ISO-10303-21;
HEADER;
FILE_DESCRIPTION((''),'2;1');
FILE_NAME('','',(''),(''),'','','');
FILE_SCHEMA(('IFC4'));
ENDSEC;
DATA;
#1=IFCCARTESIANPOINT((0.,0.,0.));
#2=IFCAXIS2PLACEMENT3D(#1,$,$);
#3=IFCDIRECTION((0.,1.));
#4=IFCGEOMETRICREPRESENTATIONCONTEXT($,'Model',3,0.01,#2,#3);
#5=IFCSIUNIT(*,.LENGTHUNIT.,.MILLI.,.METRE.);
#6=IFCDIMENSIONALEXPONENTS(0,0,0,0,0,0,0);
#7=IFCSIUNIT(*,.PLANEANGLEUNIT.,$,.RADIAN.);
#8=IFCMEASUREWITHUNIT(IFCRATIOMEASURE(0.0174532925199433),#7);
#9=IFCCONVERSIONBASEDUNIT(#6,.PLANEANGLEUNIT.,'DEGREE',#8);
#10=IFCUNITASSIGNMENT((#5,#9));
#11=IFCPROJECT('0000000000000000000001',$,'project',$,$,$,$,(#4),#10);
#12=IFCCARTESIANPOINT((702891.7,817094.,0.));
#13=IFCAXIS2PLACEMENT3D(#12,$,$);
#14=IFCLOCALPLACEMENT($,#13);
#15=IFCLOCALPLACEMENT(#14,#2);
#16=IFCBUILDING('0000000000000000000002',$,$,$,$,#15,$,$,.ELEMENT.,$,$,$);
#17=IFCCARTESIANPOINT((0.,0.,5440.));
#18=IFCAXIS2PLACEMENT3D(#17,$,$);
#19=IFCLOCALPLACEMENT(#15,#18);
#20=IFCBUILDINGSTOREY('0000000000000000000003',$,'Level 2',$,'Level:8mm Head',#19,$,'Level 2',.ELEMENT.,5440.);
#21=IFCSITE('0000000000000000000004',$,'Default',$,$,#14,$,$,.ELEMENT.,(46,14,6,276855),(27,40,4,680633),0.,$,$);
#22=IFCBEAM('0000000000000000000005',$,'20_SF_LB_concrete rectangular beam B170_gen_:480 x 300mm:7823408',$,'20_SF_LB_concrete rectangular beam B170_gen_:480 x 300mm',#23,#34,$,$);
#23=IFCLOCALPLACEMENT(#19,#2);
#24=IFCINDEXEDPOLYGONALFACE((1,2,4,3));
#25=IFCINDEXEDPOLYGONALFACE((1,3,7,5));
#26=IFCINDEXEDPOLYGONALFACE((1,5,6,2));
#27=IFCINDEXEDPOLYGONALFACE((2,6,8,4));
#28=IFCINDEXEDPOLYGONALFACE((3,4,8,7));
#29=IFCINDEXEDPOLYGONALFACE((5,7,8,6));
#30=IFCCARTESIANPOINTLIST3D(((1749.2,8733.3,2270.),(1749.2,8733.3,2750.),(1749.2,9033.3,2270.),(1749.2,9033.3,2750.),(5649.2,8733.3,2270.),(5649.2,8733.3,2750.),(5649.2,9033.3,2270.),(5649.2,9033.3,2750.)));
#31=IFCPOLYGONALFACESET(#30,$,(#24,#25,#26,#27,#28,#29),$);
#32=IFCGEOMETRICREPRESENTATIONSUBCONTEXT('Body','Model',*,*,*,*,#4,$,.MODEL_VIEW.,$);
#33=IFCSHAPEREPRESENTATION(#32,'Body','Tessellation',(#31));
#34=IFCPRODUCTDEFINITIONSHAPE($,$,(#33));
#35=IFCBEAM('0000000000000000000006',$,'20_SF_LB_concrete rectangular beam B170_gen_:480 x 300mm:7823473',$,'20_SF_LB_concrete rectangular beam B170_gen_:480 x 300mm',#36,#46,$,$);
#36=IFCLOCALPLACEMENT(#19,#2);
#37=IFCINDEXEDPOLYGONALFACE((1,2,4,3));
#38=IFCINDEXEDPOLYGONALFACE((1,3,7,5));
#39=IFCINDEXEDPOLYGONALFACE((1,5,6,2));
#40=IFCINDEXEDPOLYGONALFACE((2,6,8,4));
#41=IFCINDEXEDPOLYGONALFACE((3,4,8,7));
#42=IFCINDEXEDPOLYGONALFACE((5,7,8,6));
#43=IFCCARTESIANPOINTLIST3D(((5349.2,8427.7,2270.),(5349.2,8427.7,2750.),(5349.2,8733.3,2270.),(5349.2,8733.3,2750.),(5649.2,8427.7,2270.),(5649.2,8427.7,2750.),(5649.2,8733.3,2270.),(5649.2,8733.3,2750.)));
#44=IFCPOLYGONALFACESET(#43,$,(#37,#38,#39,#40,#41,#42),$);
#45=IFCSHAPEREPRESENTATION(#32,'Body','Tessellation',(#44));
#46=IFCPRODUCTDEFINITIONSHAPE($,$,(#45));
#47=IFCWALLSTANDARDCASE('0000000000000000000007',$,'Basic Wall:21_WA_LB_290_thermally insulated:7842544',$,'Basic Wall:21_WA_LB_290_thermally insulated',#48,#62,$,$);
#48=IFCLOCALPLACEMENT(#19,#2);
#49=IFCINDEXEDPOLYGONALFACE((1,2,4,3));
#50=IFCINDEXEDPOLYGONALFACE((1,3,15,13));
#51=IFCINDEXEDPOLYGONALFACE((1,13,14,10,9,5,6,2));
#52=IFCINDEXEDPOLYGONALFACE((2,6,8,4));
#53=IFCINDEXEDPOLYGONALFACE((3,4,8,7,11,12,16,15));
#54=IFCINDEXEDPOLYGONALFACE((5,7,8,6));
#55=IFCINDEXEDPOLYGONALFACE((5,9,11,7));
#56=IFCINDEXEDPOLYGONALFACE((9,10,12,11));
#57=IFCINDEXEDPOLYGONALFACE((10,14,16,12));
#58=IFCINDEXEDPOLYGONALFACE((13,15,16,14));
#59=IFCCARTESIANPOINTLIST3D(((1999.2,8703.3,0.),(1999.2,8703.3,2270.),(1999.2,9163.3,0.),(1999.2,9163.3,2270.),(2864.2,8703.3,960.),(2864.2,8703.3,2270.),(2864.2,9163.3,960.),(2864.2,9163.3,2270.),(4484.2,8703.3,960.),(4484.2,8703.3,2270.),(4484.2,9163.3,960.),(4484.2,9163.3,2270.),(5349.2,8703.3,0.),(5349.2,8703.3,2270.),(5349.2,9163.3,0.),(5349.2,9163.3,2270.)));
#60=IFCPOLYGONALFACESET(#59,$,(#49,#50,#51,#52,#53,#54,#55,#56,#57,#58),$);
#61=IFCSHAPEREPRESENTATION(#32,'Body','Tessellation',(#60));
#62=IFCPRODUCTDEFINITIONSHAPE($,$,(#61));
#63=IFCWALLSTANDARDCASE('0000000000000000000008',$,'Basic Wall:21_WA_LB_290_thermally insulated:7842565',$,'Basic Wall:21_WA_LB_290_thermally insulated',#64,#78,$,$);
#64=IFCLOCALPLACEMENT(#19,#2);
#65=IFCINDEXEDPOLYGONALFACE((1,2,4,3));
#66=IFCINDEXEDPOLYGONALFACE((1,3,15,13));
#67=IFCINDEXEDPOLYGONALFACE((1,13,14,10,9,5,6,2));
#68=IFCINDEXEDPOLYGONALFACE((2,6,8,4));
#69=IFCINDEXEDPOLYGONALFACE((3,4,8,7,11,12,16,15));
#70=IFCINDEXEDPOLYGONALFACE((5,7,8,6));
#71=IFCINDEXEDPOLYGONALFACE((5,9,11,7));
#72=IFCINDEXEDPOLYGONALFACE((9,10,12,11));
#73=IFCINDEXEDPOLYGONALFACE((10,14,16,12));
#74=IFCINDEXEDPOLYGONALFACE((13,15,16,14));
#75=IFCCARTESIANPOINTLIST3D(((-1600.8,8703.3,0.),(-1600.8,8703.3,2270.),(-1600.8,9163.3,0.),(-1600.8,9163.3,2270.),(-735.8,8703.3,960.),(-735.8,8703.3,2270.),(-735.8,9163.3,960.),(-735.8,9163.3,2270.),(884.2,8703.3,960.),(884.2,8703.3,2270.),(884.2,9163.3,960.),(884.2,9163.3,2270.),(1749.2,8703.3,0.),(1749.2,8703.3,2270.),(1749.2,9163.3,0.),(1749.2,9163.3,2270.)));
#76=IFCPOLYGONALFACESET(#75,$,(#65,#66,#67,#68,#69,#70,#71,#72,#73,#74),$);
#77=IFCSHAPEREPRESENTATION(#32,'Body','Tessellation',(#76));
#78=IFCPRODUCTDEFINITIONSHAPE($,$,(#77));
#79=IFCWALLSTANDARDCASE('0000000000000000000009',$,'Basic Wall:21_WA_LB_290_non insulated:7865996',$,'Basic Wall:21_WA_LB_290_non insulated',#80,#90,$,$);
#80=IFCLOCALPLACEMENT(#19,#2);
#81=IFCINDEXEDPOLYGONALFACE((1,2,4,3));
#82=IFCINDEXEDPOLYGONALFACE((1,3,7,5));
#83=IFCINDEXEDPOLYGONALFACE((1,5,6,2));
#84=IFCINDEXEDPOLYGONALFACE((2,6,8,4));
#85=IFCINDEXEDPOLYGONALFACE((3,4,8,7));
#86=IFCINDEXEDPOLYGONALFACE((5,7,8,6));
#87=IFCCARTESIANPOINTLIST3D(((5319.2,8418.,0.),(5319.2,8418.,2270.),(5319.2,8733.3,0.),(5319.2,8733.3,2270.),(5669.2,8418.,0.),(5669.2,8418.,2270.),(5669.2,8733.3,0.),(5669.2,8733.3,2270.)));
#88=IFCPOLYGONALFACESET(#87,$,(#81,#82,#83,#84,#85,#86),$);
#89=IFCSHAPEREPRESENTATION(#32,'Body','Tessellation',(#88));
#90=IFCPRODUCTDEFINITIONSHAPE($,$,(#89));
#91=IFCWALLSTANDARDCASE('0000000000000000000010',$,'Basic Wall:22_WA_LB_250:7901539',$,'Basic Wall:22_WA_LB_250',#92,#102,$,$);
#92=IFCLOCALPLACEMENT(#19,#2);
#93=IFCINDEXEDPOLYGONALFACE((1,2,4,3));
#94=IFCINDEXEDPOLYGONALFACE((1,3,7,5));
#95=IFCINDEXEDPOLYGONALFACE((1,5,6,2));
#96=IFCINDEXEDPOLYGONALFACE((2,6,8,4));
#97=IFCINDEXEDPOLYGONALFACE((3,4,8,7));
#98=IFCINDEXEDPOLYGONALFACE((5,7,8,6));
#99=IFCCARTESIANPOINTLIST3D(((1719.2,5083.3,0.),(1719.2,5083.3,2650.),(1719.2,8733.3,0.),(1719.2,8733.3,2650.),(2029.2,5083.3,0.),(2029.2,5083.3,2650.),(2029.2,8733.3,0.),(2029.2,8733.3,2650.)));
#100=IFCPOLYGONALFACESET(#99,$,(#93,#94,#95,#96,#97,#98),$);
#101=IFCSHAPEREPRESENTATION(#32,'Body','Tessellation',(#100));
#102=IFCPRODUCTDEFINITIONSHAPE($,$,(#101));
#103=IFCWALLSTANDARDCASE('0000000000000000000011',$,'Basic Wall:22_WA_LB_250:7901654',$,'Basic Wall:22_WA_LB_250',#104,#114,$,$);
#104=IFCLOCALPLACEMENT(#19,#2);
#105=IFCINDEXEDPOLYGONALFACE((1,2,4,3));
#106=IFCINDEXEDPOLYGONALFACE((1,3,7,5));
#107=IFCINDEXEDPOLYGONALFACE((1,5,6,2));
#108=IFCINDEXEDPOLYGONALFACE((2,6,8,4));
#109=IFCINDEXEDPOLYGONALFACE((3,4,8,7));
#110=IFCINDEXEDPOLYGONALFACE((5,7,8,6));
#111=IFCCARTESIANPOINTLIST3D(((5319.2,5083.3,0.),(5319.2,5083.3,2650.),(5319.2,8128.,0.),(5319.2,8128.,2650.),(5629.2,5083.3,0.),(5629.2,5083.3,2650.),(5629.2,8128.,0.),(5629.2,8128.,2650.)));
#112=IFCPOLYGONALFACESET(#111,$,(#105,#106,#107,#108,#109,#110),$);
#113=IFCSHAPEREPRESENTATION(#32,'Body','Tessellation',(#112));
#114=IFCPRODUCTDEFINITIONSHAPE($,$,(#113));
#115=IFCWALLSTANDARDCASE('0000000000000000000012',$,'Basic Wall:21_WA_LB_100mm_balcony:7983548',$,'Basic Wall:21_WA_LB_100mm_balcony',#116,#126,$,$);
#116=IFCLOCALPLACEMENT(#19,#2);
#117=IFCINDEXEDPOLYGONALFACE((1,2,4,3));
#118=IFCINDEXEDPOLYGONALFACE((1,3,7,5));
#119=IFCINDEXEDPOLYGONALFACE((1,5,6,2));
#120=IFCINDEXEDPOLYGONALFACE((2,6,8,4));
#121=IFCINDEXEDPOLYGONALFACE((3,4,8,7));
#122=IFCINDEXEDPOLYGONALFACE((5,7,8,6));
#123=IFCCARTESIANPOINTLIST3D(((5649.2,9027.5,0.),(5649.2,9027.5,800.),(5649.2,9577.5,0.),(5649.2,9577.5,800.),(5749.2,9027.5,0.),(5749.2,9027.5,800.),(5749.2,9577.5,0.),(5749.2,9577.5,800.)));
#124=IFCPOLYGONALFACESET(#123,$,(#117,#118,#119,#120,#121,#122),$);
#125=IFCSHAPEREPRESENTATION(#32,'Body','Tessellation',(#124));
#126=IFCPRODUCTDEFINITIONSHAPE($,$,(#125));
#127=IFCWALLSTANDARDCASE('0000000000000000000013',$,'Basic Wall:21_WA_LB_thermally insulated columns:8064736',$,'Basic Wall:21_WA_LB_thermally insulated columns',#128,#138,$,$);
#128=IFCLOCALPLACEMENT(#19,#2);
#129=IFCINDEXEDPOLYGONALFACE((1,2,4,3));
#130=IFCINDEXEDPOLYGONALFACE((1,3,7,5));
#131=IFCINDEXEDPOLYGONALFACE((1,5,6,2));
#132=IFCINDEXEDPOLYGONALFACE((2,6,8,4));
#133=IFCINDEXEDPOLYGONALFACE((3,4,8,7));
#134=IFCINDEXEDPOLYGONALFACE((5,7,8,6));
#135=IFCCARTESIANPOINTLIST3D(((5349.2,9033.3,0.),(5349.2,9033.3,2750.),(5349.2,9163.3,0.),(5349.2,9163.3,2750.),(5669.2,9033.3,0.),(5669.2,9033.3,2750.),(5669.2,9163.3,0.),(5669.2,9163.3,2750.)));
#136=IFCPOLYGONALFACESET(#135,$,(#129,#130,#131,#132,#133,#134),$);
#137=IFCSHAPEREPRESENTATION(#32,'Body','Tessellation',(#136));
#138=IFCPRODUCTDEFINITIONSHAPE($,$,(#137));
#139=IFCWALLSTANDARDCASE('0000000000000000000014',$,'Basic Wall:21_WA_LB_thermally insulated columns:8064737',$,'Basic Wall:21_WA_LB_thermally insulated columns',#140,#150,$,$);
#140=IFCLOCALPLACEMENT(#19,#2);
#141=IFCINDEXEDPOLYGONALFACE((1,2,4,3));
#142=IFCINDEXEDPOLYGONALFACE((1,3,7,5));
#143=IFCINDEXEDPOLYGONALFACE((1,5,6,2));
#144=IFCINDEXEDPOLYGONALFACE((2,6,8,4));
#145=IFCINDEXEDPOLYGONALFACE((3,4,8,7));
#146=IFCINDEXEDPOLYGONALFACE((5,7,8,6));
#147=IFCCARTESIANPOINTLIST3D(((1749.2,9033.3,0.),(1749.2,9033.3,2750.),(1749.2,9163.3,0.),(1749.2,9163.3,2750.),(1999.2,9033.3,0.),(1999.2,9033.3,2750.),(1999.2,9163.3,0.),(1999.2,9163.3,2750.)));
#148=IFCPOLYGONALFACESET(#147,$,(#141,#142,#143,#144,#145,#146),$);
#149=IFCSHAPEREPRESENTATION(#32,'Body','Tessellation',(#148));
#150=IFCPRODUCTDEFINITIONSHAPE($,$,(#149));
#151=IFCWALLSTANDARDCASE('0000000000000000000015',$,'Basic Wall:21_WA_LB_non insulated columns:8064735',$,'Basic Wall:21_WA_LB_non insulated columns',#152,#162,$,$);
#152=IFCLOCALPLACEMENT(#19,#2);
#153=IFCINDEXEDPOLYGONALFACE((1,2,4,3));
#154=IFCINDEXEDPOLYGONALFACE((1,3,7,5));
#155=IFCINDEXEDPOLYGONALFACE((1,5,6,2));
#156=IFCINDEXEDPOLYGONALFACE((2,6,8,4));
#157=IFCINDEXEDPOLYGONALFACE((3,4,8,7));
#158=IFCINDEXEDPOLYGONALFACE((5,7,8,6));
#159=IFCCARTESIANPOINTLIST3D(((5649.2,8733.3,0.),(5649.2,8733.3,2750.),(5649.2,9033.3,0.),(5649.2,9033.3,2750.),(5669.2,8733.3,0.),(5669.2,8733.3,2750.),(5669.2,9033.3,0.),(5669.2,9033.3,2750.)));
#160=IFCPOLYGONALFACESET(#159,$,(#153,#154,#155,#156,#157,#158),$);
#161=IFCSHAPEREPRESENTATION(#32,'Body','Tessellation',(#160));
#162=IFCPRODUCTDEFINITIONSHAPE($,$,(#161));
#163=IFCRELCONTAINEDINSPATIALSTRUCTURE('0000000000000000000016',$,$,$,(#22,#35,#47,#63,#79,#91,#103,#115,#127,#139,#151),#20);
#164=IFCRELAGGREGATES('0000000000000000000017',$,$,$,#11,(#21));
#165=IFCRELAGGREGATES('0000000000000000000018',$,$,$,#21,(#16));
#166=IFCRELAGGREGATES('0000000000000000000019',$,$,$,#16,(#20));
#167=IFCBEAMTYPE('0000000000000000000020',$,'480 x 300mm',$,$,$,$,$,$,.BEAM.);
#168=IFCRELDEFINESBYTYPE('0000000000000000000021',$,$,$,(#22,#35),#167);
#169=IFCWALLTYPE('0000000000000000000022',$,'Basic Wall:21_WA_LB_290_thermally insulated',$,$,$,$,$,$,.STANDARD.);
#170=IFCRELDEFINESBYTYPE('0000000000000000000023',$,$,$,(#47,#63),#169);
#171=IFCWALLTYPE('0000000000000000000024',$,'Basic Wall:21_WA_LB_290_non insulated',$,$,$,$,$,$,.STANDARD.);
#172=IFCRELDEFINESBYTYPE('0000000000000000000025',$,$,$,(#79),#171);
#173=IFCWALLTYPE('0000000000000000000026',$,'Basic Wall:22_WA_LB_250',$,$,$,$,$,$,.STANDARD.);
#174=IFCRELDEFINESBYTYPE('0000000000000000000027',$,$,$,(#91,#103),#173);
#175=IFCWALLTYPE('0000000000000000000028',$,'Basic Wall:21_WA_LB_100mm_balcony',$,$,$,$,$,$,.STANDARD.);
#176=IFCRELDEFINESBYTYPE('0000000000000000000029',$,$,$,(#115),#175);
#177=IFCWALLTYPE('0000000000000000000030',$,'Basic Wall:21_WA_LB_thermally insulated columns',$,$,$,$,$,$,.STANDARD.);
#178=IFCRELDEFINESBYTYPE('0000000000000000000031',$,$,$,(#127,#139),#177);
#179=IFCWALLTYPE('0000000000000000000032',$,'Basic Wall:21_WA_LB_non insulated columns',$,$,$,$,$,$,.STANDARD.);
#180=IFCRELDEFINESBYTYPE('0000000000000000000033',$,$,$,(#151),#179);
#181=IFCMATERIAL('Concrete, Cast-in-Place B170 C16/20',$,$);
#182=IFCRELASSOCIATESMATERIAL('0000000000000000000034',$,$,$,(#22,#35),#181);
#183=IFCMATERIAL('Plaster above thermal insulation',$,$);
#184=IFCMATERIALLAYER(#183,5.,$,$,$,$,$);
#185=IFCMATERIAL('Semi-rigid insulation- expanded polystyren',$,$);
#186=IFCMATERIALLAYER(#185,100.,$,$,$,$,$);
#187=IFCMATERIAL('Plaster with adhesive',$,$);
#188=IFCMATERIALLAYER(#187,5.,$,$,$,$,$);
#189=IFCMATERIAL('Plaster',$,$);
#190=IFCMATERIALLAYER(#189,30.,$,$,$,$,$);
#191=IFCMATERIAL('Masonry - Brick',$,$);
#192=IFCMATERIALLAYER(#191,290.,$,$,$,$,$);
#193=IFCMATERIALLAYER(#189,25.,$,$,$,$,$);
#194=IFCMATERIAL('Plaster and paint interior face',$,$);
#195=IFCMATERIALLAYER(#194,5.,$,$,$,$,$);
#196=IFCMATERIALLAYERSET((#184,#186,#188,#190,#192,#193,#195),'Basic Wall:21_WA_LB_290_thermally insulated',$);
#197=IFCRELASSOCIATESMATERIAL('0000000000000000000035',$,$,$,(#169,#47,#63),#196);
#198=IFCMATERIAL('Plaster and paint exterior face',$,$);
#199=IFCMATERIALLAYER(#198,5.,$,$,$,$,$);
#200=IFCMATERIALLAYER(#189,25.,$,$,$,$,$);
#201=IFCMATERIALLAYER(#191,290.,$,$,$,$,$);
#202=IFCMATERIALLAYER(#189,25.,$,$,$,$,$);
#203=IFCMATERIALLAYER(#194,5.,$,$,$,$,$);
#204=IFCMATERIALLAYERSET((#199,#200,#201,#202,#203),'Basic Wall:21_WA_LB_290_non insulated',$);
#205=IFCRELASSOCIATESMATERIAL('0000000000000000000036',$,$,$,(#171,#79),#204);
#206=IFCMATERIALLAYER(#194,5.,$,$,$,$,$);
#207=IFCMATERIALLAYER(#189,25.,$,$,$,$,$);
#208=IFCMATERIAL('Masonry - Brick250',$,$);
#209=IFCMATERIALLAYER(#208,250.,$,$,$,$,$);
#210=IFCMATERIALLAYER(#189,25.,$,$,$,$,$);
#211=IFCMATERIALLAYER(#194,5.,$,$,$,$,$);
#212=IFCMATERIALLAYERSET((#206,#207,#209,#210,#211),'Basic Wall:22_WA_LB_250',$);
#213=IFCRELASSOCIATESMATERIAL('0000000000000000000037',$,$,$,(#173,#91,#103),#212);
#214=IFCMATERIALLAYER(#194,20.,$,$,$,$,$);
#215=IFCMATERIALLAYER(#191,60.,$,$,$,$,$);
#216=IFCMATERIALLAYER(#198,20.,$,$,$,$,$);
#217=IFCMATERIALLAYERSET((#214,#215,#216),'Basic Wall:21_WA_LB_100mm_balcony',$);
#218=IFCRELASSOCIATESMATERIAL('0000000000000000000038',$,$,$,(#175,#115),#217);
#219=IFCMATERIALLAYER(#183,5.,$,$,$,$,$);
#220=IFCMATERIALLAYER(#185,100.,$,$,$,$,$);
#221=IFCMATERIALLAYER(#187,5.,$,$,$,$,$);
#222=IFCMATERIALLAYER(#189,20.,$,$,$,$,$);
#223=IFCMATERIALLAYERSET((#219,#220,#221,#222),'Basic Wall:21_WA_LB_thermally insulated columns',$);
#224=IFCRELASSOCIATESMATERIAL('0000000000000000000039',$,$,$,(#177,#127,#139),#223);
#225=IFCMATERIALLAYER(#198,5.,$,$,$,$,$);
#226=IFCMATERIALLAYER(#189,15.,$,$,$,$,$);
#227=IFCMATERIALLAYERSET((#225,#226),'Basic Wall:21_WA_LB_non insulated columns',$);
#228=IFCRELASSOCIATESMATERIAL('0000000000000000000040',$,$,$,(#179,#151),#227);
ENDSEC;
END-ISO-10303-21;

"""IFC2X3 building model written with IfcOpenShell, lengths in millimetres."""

from ifc_helpers import new_model, entity, si_unit, converted_unit, direction, frame, frame_2d, origin, place, context, subcontext, project, spatial, rectangle, extrude, clip, halfspace, material, layer, layer_set, layer_usage, type_object, element, save


model = new_model("IFC2X3")

# Units and contexts
model_context = context("Model", 3, precision=0.01, world=origin(), true_north=direction((0.0, 1.0)))
body_context = subcontext(model_context, "Body", "Model", "MODEL_VIEW")
ifc_project = project(units=[si_unit("LENGTHUNIT", "METRE", prefix="MILLI"), converted_unit("PLANEANGLEUNIT", "DEGREE", entity("IfcRatioMeasure", 0.0174532925199433), si_unit("PLANEANGLEUNIT", "RADIAN"), dimensions=[0, 0, 0, 0, 0, 0, 0])], contexts=[model_context])

# Site, building, storey
site_placement = place(None, frame((702891.7, 817094.0, 0.0)))
site = spatial("IfcSite", under=ifc_project, at=site_placement, Name="Default", CompositionType="ELEMENT", RefLatitude=(46, 14, 6, 276855), RefLongitude=(27, 40, 4, 680633), RefElevation=0.0)
building_placement = place(site_placement, origin())
building = spatial("IfcBuilding", under=site, at=building_placement, CompositionType="ELEMENT")
storey_placement = place(building_placement, frame((0.0, 0.0, 5440.0)))
storey = spatial("IfcBuildingStorey", under=building, at=storey_placement, Name="Level 2", ObjectType="Level:8mm Head", LongName="Level 2", CompositionType="ELEMENT", Elevation=5440.0)

# Beams
ifc_material_1 = material(Name="Concrete, Cast-in-Place B170 C16/20")
beam_type = type_object("IfcBeamType", Name="480 x 300mm", PredefinedType="BEAM")
beam_1_placement = place(storey_placement, frame((1749.2, 8883.3, 0.0)))
element("IfcBeam", 1, at=beam_1_placement, inside=storey, type_object=beam_type, material=ifc_material_1, Name="20_SF_LB_concrete rectangular beam B170_gen_:480 x 300mm:7823408", ObjectType="20_SF_LB_concrete rectangular beam B170_gen_:480 x 300mm", context=body_context, shape_type="SweptSolid", body=[
    extrude(rectangle(XDim=480.0, YDim=300.0, at=frame_2d((0.0, 0.0), x_axis=(1.0, 0.0))), frame((0.0, 0.0, 2510.0), z_axis=(1.0, 0.0, 0.0), x_axis=(0.0, 0.0, -1.0)), (0.0, 0.0, 1.0), 3900.0),
])
beam_2_placement = place(storey_placement, frame((5499.2, 8427.7, 0.0), z_axis=(0.0, 0.0, 1.0), x_axis=(0.0, 1.0, 0.0)))
element("IfcBeam", 2, at=beam_2_placement, inside=storey, type_object=beam_type, material=ifc_material_1, Name="20_SF_LB_concrete rectangular beam B170_gen_:480 x 300mm:7823473", ObjectType="20_SF_LB_concrete rectangular beam B170_gen_:480 x 300mm", context=body_context, shape_type="SweptSolid", body=[
    extrude(rectangle(XDim=480.0, YDim=300.0, at=frame_2d((0.0, 0.0), x_axis=(1.0, 0.0))), frame((0.0, 0.0, 2510.0), z_axis=(1.0, 0.0, 0.0), x_axis=(0.0, 0.0, -1.0)), (0.0, 0.0, 1.0), 305.6),
])

# Walls, openings
ifc_material_2 = material(Name="Plaster above thermal insulation")
ifc_layer_1 = layer(ifc_material_2, 5.0)
ifc_material_3 = material(Name="Semi-rigid insulation- expanded polystyren")
ifc_layer_2 = layer(ifc_material_3, 100.0)
ifc_material_4 = material(Name="Plaster with adhesive")
ifc_layer_3 = layer(ifc_material_4, 5.0)
ifc_material_5 = material(Name="Plaster")
ifc_layer_4 = layer(ifc_material_5, 30.0)
ifc_material_6 = material(Name="Masonry - Brick")
ifc_layer_5 = layer(ifc_material_6, 290.0)
ifc_layer_6 = layer(ifc_material_5, 25.0)
ifc_material_7 = material(Name="Plaster and paint interior face")
ifc_layer_7 = layer(ifc_material_7, 5.0)
ifc_layer_set_1 = layer_set([ifc_layer_1, ifc_layer_2, ifc_layer_3, ifc_layer_4, ifc_layer_5, ifc_layer_6, ifc_layer_7], Name="Basic Wall:21_WA_LB_290_thermally insulated")
ifc_layer_usage_1 = layer_usage(ifc_layer_set_1, "AXIS2", "POSITIVE", -230.0)
wall_type_1 = type_object("IfcWallType", Name="Basic Wall:21_WA_LB_290_thermally insulated", PredefinedType="STANDARD", material=ifc_layer_set_1)
wall_1_placement = place(storey_placement, frame((5349.2, 8933.3, 0.0), z_axis=(0.0, 0.0, 1.0), x_axis=(-1.0, 0.0, 0.0)))
wall_1 = element("IfcWallStandardCase", 3, at=wall_1_placement, inside=storey, type_object=wall_type_1, material=ifc_layer_usage_1, Name="Basic Wall:21_WA_LB_290_thermally insulated:7842544", ObjectType="Basic Wall:21_WA_LB_290_thermally insulated", context=body_context, shape_type="SweptSolid", body=[
    extrude(rectangle(XDim=3350.0, YDim=460.0, at=frame_2d((1675.0, 0.0), x_axis=(-1.0, 0.0))), origin(), (0.0, 0.0, 1.0), 2270.0),
])
opening_1_placement = place(wall_1_placement, frame((2485.0, 230.0, 960.0)))
element("IfcOpeningElement", 4, at=opening_1_placement, cuts=wall_1, ObjectType="Opening", context=body_context, shape_type="SweptSolid", body=[
    extrude(rectangle(XDim=1320.0, YDim=1620.0, at=frame_2d((660.0, 810.0), x_axis=(1.0, 0.0))), frame((0.0, 0.0, 0.0), z_axis=(0.0, -1.0, 0.0), x_axis=(0.0, 0.0, 1.0)), (0.0, 0.0, 1.0), 460.0),
])
ifc_layer_usage_2 = layer_usage(ifc_layer_set_1, "AXIS2", "POSITIVE", -230.0)
wall_2_placement = place(storey_placement, frame((1749.2, 8933.3, 0.0), z_axis=(0.0, 0.0, 1.0), x_axis=(-1.0, 0.0, 0.0)))
wall_2 = element("IfcWallStandardCase", 5, at=wall_2_placement, inside=storey, type_object=wall_type_1, material=ifc_layer_usage_2, Name="Basic Wall:21_WA_LB_290_thermally insulated:7842565", ObjectType="Basic Wall:21_WA_LB_290_thermally insulated", context=body_context, shape_type="SweptSolid", body=[
    extrude(rectangle(XDim=3350.0, YDim=460.0, at=frame_2d((1675.0, 0.0), x_axis=(-1.0, 0.0))), origin(), (0.0, 0.0, 1.0), 2270.0),
])
opening_2_placement = place(wall_2_placement, frame((2485.0, 230.0, 960.0)))
element("IfcOpeningElement", 6, at=opening_2_placement, cuts=wall_2, ObjectType="Opening", context=body_context, shape_type="SweptSolid", body=[
    extrude(rectangle(XDim=1320.0, YDim=1620.0, at=frame_2d((660.0, 810.0), x_axis=(1.0, 0.0))), frame((0.0, 0.0, 0.0), z_axis=(0.0, -1.0, 0.0), x_axis=(0.0, 0.0, 1.0)), (0.0, 0.0, 1.0), 460.0),
])

# Walls
ifc_material_8 = material(Name="Plaster and paint exterior face")
ifc_layer_8 = layer(ifc_material_8, 5.0)
ifc_layer_9 = layer(ifc_material_5, 25.0)
ifc_layer_10 = layer(ifc_material_6, 290.0)
ifc_layer_11 = layer(ifc_material_5, 25.0)
ifc_layer_12 = layer(ifc_material_7, 5.0)
ifc_layer_set_2 = layer_set([ifc_layer_8, ifc_layer_9, ifc_layer_10, ifc_layer_11, ifc_layer_12], Name="Basic Wall:21_WA_LB_290_non insulated")
ifc_layer_usage_3 = layer_usage(ifc_layer_set_2, "AXIS2", "POSITIVE", -175.0)
wall_type_2 = type_object("IfcWallType", Name="Basic Wall:21_WA_LB_290_non insulated", PredefinedType="STANDARD", material=ifc_layer_set_2)
wall_3_placement = place(storey_placement, frame((5494.2, 8418.0, 0.0), z_axis=(0.0, 0.0, 1.0), x_axis=(0.0, 1.0, 0.0)))
element("IfcWallStandardCase", 7, at=wall_3_placement, inside=storey, type_object=wall_type_2, material=ifc_layer_usage_3, Name="Basic Wall:21_WA_LB_290_non insulated:7865996", ObjectType="Basic Wall:21_WA_LB_290_non insulated", context=body_context, shape_type="SweptSolid", body=[
    extrude(rectangle(XDim=315.3, YDim=350.0, at=frame_2d((157.7, 0.0), x_axis=(-1.0, 0.0))), origin(), (0.0, 0.0, 1.0), 2270.0),
])
ifc_layer_13 = layer(ifc_material_7, 5.0)
ifc_layer_14 = layer(ifc_material_5, 25.0)
ifc_material_9 = material(Name="Masonry - Brick250")
ifc_layer_15 = layer(ifc_material_9, 250.0)
ifc_layer_16 = layer(ifc_material_5, 25.0)
ifc_layer_17 = layer(ifc_material_7, 5.0)
ifc_layer_set_3 = layer_set([ifc_layer_13, ifc_layer_14, ifc_layer_15, ifc_layer_16, ifc_layer_17], Name="Basic Wall:22_WA_LB_250")
ifc_layer_usage_4 = layer_usage(ifc_layer_set_3, "AXIS2", "NEGATIVE", 155.0)
wall_type_3 = type_object("IfcWallType", Name="Basic Wall:22_WA_LB_250", PredefinedType="STANDARD", material=ifc_layer_set_3)
wall_4_placement = place(storey_placement, frame((1874.2, 8733.3, 0.0), z_axis=(0.0, 0.0, 1.0), x_axis=(0.0, -1.0, 0.0)))
element("IfcWallStandardCase", 8, at=wall_4_placement, inside=storey, type_object=wall_type_3, material=ifc_layer_usage_4, Name="Basic Wall:22_WA_LB_250:7901539", ObjectType="Basic Wall:22_WA_LB_250", context=body_context, shape_type="SweptSolid", body=[
    extrude(rectangle(XDim=3650.0, YDim=310.0, at=frame_2d((1825.0, 0.0), x_axis=(-1.0, 0.0))), origin(), (0.0, 0.0, 1.0), 2650.0),
])
ifc_layer_usage_5 = layer_usage(ifc_layer_set_3, "AXIS2", "NEGATIVE", 155.0)
wall_5_placement = place(storey_placement, frame((5474.2, 8128.0, 0.0), z_axis=(0.0, 0.0, 1.0), x_axis=(0.0, -1.0, 0.0)))
element("IfcWallStandardCase", 9, at=wall_5_placement, inside=storey, type_object=wall_type_3, material=ifc_layer_usage_5, Name="Basic Wall:22_WA_LB_250:7901654", ObjectType="Basic Wall:22_WA_LB_250", context=body_context, shape_type="SweptSolid", body=[
    extrude(rectangle(XDim=3044.7, YDim=310.0, at=frame_2d((1522.3, 0.0), x_axis=(-1.0, 0.0))), origin(), (0.0, 0.0, 1.0), 2650.0),
])
ifc_layer_18 = layer(ifc_material_7, 20.0)
ifc_layer_19 = layer(ifc_material_6, 60.0)
ifc_layer_20 = layer(ifc_material_8, 20.0)
ifc_layer_set_4 = layer_set([ifc_layer_18, ifc_layer_19, ifc_layer_20], Name="Basic Wall:21_WA_LB_100mm_balcony")
ifc_layer_usage_6 = layer_usage(ifc_layer_set_4, "AXIS2", "NEGATIVE", 50.0)
wall_type_4 = type_object("IfcWallType", Name="Basic Wall:21_WA_LB_100mm_balcony", PredefinedType="STANDARD", material=ifc_layer_set_4)
wall_6_placement = place(storey_placement, frame((5699.2, 9577.5, 0.0), z_axis=(0.0, 0.0, 1.0), x_axis=(0.0, -1.0, 0.0)))
element("IfcWallStandardCase", 10, at=wall_6_placement, inside=storey, type_object=wall_type_4, material=ifc_layer_usage_6, Name="Basic Wall:21_WA_LB_100mm_balcony:7983548", ObjectType="Basic Wall:21_WA_LB_100mm_balcony", context=body_context, shape_type="SweptSolid", body=[
    extrude(rectangle(XDim=550.0, YDim=100.0, at=frame_2d((275.0, 0.0), x_axis=(-1.0, 0.0))), origin(), (0.0, 0.0, 1.0), 800.0),
])
ifc_layer_21 = layer(ifc_material_2, 5.0)
ifc_layer_22 = layer(ifc_material_3, 100.0)
ifc_layer_23 = layer(ifc_material_4, 5.0)
ifc_layer_24 = layer(ifc_material_5, 20.0)
ifc_layer_set_5 = layer_set([ifc_layer_21, ifc_layer_22, ifc_layer_23, ifc_layer_24], Name="Basic Wall:21_WA_LB_thermally insulated columns")
ifc_layer_usage_7 = layer_usage(ifc_layer_set_5, "AXIS2", "NEGATIVE", 65.0)
wall_type_5 = type_object("IfcWallType", Name="Basic Wall:21_WA_LB_thermally insulated columns", PredefinedType="STANDARD", material=ifc_layer_set_5)
wall_7_placement = place(storey_placement, frame((5349.2, 9098.3, 0.0)))
element("IfcWallStandardCase", 11, at=wall_7_placement, inside=storey, type_object=wall_type_5, material=ifc_layer_usage_7, Name="Basic Wall:21_WA_LB_thermally insulated columns:8064736", ObjectType="Basic Wall:21_WA_LB_thermally insulated columns", context=body_context, shape_type="Clipping", body=[
    clip(extrude(rectangle(XDim=320.0, YDim=130.0, at=frame_2d((160.0, 0.0), x_axis=(-1.0, 0.0))), origin(), (0.0, 0.0, 1.0), 2750.0), halfspace(frame((0.0, 0.0, -5500.0)), True)),
])
ifc_layer_usage_8 = layer_usage(ifc_layer_set_5, "AXIS2", "NEGATIVE", 65.0)
wall_8_placement = place(storey_placement, frame((1749.2, 9098.3, 0.0)))
element("IfcWallStandardCase", 12, at=wall_8_placement, inside=storey, type_object=wall_type_5, material=ifc_layer_usage_8, Name="Basic Wall:21_WA_LB_thermally insulated columns:8064737", ObjectType="Basic Wall:21_WA_LB_thermally insulated columns", context=body_context, shape_type="Clipping", body=[
    clip(extrude(rectangle(XDim=250.0, YDim=130.0, at=frame_2d((125.0, 0.0), x_axis=(-1.0, 0.0))), origin(), (0.0, 0.0, 1.0), 2750.0), halfspace(frame((0.0, 0.0, -5500.0)), True)),
])
ifc_layer_25 = layer(ifc_material_8, 5.0)
ifc_layer_26 = layer(ifc_material_5, 15.0)
ifc_layer_set_6 = layer_set([ifc_layer_25, ifc_layer_26], Name="Basic Wall:21_WA_LB_non insulated columns")
ifc_layer_usage_9 = layer_usage(ifc_layer_set_6, "AXIS2", "NEGATIVE", 10.0)
wall_type_6 = type_object("IfcWallType", Name="Basic Wall:21_WA_LB_non insulated columns", PredefinedType="STANDARD", material=ifc_layer_set_6)
wall_9_placement = place(storey_placement, frame((5659.2, 9033.3, 0.0), z_axis=(0.0, 0.0, 1.0), x_axis=(0.0, -1.0, 0.0)))
element("IfcWallStandardCase", 13, at=wall_9_placement, inside=storey, type_object=wall_type_6, material=ifc_layer_usage_9, Name="Basic Wall:21_WA_LB_non insulated columns:8064735", ObjectType="Basic Wall:21_WA_LB_non insulated columns", context=body_context, shape_type="Clipping", body=[
    clip(extrude(rectangle(XDim=300.0, YDim=20.0, at=frame_2d((150.0, 0.0), x_axis=(-1.0, 0.0))), origin(), (0.0, 0.0, 1.0), 2750.0), halfspace(frame((0.0, 0.0, -5500.0)), True)),
])

save(model, "model.ifc")
